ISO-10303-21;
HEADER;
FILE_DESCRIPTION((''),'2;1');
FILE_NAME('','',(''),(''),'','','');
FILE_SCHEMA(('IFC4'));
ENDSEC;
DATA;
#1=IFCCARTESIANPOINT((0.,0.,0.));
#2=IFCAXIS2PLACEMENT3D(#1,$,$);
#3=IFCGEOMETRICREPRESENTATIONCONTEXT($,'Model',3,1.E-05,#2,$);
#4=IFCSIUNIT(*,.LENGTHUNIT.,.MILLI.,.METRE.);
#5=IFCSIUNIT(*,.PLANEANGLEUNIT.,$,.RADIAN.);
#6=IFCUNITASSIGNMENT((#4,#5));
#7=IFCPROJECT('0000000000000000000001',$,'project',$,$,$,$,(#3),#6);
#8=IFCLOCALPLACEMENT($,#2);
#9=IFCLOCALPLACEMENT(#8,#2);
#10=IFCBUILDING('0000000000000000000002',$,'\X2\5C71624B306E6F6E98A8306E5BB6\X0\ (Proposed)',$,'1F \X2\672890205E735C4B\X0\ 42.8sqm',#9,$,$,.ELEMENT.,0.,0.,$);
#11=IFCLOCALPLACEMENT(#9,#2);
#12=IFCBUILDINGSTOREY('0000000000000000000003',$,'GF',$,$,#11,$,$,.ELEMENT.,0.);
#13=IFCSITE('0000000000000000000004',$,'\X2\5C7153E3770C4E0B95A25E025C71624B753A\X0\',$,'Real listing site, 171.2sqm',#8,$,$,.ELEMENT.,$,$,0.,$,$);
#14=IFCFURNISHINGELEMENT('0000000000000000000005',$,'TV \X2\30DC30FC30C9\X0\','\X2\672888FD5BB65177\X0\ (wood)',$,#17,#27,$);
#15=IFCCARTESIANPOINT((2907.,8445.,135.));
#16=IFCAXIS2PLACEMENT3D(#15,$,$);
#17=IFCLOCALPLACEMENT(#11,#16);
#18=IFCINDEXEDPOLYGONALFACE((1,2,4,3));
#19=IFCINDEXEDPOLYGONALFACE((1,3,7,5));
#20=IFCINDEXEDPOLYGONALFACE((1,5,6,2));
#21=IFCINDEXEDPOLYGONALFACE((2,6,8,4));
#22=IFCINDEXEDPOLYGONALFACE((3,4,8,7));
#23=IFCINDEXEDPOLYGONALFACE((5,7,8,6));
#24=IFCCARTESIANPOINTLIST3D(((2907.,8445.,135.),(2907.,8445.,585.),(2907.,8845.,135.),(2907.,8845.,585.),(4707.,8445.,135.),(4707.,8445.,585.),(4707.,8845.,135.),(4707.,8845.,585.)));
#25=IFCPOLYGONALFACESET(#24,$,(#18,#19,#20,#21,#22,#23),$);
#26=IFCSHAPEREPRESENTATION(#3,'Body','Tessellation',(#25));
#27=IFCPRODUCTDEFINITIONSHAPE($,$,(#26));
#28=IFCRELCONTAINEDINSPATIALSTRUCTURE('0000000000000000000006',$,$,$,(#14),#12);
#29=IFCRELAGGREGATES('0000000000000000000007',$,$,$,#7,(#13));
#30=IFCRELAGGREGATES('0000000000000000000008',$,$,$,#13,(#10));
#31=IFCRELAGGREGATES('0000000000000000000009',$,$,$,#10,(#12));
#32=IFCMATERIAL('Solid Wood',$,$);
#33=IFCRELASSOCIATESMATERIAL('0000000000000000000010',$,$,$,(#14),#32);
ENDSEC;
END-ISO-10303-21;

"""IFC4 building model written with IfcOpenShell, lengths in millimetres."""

from ifc_helpers import new_model, si_unit, frame, frame_2d, origin, place, context, project, spatial, rectangle, extrude, material, element, save


model = new_model("IFC4")

# Units and contexts
model_context = context("Model", 3, precision=1e-05, world=origin())
ifc_project = project(units=[si_unit("LENGTHUNIT", "METRE", prefix="MILLI"), si_unit("PLANEANGLEUNIT", "RADIAN")], contexts=[model_context])

# Site, building, storey
site_placement = place(None, origin())
site = spatial("IfcSite", under=ifc_project, at=site_placement, Name="山口県下関市山手町", ObjectType="Real listing site, 171.2sqm", CompositionType="ELEMENT", RefElevation=0.0)
building_placement = place(site_placement, origin())
building = spatial("IfcBuilding", under=site, at=building_placement, Name="山手の潮風の家 (Proposed)", ObjectType="1F 木造平屋 42.8sqm", CompositionType="ELEMENT", ElevationOfRefHeight=0.0, ElevationOfTerrain=0.0)
storey_placement = place(building_placement, origin())
storey = spatial("IfcBuildingStorey", under=building, at=storey_placement, Name="GF", CompositionType="ELEMENT", Elevation=0.0)

# Shared definitions
ifc_material_1 = material(Name="Solid Wood")

# Furnishing element
furnishing_placement = place(storey_placement, frame((2907.0, 8445.0, 135.0)))
element("IfcFurnishingElement", 1, at=furnishing_placement, inside=storey, material=ifc_material_1, Name="TV ボード", Description="木製家具 (wood)", context=model_context, shape_type="SweptSolid", body=[
    extrude(rectangle(XDim=1800.0, YDim=400.0, at=frame_2d((900.0, 200.0))), frame((2907.0, 8445.0, 135.0)), (0.0, 0.0, 1.0), 450.0),
])

save(model, "model.ifc")
